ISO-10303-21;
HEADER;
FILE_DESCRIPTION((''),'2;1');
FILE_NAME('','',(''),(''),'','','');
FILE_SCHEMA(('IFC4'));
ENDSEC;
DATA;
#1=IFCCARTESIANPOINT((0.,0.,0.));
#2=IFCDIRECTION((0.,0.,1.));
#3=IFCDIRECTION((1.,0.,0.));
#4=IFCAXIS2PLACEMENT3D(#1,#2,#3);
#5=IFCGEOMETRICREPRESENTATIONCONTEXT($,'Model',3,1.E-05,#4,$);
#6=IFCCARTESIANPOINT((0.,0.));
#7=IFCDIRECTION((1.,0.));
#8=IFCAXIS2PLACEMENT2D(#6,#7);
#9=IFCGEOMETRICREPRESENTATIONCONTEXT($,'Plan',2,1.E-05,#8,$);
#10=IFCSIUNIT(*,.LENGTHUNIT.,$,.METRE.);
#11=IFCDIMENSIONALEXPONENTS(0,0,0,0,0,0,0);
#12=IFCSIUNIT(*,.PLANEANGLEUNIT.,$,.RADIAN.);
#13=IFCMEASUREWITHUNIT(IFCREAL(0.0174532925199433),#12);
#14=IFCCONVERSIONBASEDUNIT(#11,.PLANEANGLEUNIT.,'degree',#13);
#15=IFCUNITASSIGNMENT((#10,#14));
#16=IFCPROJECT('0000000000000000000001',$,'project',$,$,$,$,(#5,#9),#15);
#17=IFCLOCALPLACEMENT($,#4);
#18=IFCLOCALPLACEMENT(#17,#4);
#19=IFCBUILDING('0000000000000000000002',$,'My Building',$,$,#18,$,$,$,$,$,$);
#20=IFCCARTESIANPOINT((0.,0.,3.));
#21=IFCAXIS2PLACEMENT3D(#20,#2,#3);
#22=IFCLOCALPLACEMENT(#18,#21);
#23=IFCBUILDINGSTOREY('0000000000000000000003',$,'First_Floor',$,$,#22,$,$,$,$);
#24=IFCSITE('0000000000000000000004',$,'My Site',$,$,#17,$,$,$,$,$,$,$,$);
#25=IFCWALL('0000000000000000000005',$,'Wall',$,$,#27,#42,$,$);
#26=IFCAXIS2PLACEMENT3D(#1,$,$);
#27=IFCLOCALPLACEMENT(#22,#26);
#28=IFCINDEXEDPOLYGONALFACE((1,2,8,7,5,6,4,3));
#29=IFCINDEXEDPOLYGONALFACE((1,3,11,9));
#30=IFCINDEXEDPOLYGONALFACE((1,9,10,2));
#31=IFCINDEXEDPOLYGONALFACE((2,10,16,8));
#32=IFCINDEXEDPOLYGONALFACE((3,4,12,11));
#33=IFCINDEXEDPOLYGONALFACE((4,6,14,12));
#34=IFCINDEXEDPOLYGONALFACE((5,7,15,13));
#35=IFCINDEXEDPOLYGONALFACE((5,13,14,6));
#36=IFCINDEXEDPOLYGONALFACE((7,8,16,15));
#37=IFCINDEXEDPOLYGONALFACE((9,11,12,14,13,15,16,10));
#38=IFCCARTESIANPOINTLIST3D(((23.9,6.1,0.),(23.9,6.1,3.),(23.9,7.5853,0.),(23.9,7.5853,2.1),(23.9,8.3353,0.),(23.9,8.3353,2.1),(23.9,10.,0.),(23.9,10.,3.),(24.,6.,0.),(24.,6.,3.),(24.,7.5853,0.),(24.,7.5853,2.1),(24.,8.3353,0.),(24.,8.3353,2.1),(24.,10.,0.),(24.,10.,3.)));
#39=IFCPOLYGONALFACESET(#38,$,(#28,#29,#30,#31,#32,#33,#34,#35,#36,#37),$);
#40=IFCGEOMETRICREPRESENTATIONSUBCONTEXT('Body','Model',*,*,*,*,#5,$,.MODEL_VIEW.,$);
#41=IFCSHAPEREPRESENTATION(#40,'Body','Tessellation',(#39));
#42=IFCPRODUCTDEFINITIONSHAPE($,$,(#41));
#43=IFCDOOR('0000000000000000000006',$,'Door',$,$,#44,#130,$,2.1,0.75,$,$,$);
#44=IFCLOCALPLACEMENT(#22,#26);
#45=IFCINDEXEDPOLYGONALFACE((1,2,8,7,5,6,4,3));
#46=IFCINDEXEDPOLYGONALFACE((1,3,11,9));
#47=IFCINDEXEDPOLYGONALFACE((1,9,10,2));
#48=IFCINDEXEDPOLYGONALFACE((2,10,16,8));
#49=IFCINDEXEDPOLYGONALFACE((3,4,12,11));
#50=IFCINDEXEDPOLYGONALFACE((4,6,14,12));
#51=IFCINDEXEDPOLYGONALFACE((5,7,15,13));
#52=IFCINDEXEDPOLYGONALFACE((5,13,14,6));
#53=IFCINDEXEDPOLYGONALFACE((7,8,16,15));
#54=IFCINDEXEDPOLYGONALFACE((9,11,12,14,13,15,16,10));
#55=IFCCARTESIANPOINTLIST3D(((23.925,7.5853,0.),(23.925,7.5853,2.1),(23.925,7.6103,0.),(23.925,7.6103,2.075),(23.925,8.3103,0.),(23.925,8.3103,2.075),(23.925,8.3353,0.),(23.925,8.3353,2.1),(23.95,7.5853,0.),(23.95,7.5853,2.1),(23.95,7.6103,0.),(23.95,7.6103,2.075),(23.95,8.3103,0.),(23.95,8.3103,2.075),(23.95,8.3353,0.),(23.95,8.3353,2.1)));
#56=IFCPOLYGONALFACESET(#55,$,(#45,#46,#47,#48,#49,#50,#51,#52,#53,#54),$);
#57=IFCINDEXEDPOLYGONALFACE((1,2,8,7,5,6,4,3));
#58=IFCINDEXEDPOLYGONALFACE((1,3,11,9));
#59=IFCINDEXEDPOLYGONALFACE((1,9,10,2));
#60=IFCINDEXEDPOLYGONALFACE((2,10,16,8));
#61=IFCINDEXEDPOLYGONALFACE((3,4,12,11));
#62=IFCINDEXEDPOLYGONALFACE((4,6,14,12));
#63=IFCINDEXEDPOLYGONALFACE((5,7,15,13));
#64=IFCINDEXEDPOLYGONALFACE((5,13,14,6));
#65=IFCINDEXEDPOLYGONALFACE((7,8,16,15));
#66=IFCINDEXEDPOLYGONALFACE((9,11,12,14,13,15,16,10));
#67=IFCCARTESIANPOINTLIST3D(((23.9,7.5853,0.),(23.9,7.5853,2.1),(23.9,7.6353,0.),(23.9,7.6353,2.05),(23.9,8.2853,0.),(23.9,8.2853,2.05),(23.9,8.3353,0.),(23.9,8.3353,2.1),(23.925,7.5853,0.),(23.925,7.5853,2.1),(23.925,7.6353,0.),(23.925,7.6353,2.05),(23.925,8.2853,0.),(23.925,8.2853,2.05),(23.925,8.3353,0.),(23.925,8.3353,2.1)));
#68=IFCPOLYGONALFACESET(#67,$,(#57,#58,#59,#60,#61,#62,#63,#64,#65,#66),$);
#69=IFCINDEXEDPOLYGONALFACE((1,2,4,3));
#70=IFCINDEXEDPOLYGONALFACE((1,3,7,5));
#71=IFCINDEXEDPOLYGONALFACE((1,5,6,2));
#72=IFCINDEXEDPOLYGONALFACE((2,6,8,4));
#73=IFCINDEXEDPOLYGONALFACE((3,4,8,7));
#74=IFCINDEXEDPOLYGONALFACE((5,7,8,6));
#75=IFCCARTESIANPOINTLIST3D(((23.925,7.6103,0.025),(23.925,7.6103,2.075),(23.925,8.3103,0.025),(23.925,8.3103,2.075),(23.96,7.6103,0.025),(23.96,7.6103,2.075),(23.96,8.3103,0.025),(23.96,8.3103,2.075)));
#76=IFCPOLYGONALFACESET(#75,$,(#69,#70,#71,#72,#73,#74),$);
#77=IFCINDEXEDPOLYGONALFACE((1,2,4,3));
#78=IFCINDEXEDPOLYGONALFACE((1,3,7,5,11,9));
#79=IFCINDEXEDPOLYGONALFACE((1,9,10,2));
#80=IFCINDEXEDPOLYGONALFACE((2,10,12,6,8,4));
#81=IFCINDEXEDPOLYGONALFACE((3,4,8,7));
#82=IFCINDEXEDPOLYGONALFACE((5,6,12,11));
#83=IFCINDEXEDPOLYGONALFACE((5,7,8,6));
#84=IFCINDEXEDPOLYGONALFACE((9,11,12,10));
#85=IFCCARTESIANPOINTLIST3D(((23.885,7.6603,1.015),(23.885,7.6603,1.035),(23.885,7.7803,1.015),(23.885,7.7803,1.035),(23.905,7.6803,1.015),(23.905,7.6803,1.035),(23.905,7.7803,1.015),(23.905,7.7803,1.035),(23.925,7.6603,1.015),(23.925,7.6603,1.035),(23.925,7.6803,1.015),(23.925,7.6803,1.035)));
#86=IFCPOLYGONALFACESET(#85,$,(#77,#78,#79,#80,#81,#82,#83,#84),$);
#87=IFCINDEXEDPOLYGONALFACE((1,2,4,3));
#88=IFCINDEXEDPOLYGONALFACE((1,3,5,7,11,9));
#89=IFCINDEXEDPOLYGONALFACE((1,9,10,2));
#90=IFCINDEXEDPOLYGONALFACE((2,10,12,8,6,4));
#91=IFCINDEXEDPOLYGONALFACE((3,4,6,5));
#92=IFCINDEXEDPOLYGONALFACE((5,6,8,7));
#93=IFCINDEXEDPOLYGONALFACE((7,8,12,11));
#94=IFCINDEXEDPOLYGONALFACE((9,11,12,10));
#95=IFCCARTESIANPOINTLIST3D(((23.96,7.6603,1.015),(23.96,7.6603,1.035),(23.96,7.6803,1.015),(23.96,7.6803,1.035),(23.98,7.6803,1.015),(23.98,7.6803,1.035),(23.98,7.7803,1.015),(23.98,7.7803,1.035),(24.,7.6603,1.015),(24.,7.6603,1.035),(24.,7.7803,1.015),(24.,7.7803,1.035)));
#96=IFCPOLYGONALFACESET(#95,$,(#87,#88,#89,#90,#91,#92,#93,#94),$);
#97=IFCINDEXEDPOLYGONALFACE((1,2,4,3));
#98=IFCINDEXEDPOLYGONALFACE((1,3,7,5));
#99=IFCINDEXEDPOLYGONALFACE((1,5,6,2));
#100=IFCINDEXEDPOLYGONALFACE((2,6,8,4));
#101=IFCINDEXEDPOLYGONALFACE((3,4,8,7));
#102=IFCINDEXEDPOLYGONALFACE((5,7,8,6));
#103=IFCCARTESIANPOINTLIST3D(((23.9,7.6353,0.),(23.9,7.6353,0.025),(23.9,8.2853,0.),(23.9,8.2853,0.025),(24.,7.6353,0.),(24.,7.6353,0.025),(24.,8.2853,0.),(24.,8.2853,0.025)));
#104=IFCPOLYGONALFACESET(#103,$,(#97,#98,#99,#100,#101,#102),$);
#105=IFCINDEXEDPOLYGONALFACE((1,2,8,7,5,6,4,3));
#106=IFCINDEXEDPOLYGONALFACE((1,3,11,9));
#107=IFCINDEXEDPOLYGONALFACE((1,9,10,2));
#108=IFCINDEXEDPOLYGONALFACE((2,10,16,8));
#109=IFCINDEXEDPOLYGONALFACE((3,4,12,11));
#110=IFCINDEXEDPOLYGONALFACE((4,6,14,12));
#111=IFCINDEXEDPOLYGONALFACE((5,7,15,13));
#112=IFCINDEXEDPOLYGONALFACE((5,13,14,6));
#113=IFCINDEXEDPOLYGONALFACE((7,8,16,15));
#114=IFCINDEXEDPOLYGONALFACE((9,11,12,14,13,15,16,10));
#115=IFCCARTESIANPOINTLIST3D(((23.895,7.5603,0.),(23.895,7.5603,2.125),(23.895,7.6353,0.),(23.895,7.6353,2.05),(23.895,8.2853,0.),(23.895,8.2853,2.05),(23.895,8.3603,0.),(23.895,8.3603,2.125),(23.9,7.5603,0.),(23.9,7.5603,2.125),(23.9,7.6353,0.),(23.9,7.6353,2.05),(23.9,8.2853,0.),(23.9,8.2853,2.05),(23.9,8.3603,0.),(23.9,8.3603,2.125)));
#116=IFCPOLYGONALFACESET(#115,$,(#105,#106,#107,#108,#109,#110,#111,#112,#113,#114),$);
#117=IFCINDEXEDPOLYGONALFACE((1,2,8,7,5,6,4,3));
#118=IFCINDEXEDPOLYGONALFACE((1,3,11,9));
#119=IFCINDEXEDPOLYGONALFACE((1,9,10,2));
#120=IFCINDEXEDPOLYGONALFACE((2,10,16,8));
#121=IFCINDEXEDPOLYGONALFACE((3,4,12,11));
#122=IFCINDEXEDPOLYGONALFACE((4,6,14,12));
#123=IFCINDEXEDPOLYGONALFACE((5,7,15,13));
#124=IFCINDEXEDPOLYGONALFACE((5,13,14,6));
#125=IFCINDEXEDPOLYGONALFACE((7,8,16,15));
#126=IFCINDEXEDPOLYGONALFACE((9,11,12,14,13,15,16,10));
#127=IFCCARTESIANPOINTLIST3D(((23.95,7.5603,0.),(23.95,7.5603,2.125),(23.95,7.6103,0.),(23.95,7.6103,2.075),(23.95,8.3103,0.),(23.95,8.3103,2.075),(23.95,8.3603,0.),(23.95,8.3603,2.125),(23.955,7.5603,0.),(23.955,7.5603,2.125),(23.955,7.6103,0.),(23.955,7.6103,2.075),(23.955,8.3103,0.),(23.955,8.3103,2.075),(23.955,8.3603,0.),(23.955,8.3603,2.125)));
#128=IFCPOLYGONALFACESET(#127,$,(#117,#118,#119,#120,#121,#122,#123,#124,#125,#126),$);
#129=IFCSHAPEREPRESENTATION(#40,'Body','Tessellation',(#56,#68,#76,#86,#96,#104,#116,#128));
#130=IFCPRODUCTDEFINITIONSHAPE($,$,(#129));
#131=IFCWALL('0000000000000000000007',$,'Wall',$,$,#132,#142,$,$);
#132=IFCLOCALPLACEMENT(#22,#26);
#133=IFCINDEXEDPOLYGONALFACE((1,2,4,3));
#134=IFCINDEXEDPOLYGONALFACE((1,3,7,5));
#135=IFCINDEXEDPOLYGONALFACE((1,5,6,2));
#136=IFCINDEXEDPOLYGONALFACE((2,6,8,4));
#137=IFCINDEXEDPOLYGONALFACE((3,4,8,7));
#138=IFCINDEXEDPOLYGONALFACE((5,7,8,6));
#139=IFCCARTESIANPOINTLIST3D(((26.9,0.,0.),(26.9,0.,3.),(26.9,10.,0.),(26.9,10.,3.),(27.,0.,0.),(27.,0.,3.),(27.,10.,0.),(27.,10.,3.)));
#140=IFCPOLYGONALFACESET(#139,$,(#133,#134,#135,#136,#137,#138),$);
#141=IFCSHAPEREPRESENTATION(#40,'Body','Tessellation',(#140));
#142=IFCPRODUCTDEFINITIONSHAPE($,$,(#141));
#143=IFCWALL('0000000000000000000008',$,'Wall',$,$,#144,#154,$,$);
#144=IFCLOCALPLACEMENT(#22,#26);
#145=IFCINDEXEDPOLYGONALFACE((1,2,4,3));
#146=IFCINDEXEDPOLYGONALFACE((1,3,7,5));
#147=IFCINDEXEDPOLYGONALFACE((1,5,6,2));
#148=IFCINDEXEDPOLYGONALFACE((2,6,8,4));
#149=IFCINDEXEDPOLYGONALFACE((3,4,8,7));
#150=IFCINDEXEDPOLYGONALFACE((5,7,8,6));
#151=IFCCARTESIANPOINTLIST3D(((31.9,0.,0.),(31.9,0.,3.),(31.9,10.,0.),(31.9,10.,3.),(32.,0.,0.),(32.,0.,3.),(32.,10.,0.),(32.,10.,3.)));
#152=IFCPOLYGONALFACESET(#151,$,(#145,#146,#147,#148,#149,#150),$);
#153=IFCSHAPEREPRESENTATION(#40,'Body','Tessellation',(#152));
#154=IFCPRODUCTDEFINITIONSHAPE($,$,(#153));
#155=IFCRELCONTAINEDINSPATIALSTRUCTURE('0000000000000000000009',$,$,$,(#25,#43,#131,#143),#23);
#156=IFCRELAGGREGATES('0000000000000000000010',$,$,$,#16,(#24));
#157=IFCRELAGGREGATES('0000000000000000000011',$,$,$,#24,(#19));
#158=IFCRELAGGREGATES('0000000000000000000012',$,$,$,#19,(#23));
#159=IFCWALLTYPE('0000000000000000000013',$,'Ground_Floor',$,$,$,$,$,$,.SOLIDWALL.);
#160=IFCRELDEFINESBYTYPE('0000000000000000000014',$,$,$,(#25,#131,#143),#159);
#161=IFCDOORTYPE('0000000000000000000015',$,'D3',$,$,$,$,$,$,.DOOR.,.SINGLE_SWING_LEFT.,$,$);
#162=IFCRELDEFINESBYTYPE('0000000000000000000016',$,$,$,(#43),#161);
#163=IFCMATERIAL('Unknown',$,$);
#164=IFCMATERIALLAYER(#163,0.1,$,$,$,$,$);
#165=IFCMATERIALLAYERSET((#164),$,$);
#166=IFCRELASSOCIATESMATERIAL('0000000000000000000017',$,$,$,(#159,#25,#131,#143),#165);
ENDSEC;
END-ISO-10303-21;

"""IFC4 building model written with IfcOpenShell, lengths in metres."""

from ifc_helpers import new_model, entity, si_unit, converted_unit, frame, origin_with_axes, origin_2d_with_axis, place, context, subcontext, project, spatial, line, indexed_curve, outline, extrude, shape, source, transform, mapped, material, layer, layer_set, layer_usage, type_object, type_shapes, element, fill, save


model = new_model("IFC4")

# Units and contexts
model_context = context("Model", 3, precision=1e-05, world=origin_with_axes())
plan_context = context("Plan", 2, precision=1e-05, world=origin_2d_with_axis())
body_context_1 = subcontext(model_context, "Body", "Model", "MODEL_VIEW")
body_context_2 = subcontext(plan_context, "Body", "Plan", "PLAN_VIEW")
ifc_project = project(units=[si_unit("LENGTHUNIT", "METRE"), converted_unit("PLANEANGLEUNIT", "degree", entity("IfcReal", 0.0174532925199433), si_unit("PLANEANGLEUNIT", "RADIAN"), dimensions=[0, 0, 0, 0, 0, 0, 0])], contexts=[model_context, plan_context])

# Site, building, storey
site_placement = place(None, origin_with_axes())
site = spatial("IfcSite", under=ifc_project, at=site_placement, Name="My Site")
building_placement = place(site_placement, origin_with_axes())
building = spatial("IfcBuilding", under=site, at=building_placement, Name="My Building")
storey_placement = place(building_placement, frame((0.0, 0.0, 3.0), z_axis=(0.0, 0.0, 1.0), x_axis=(1.0, 0.0, 0.0)))
storey = spatial("IfcBuildingStorey", under=building, at=storey_placement, Name="First_Floor")

# Shared definitions
ifc_material = material(Name="Unknown")

# Wall, opening, door
ifc_layer = layer(ifc_material, 0.1)
ifc_layer_set = layer_set([ifc_layer])
ifc_layer_usage_1 = layer_usage(ifc_layer_set, "AXIS2", "POSITIVE", 0.0)
wall_type = type_object("IfcWallType", Name="Ground_Floor", PredefinedType="SOLIDWALL", material=ifc_layer_set)
wall_1_placement = place(storey_placement, frame((24.0, 6.0, 0.0), z_axis=(0.0, 0.0, 1.0), x_axis=(0.0, 1.0, 0.0)))
wall_1 = element("IfcWall", 1, at=wall_1_placement, inside=storey, type_object=wall_type, material=ifc_layer_usage_1, Name="Wall", context=body_context_1, shape_type="SweptSolid", body=[
    extrude(outline(indexed_curve([(0.0, 0.0), (0.1, 0.1), (4.0, 0.1), (4.0, 0.0)], segments=[line(1, 2, 3, 4, 1)])), origin_with_axes(), (0.0, 0.0, 1.0), 3.0),
])
shared_shape_1 = source(origin_with_axes(), body_context_1, "Body", "SweptSolid", [
    extrude(outline(indexed_curve([(0.0, 0.0), (0.75, 0.0), (0.75, 2.1), (0.0, 2.1)], segments=[line(1, 2, 3, 4, 1)])), frame((0.0, -0.6, 0.0), z_axis=(0.0, -1.0, 0.0), x_axis=(1.0, 0.0, 0.0)), (0.0, 0.0, -1.0), 1.2),
])
opening_1_placement = place(wall_1_placement, frame((2.3353, 0.1, 0.0), z_axis=(0.0, 0.0, 1.0), x_axis=(-1.0, 0.0, 0.0)))
opening_1 = element("IfcOpeningElement", 2, at=opening_1_placement, cuts=wall_1, PredefinedType="OPENING", context=body_context_1, shape_type="MappedRepresentation", body=[
    mapped(shared_shape_1, transform((0.0, 0.0, 0.0), x_axis=(1.0, 0.0, 0.0), y_axis=(0.0, 1.0, 0.0), z_axis=(0.0, 0.0, 1.0), scale=1.0)),
])
door_type_1 = type_object("IfcDoorType", Name="D3", OperationType="SINGLE_SWING_LEFT", PredefinedType="DOOR")
shared_shape_2 = source(origin_with_axes(), body_context_1, "Body", "SweptSolid", [
    extrude(outline(indexed_curve([(0.0, 0.0), (0.0, 2.1), (0.75, 2.1), (0.75, 0.0), (0.725, 0.0), (0.725, 2.075), (0.025, 2.075), (0.025, 0.0)], segments=[line(1, 2, 3, 4, 5, 6, 7, 8, 1)])), frame((0.0, 0.025, 0.0), z_axis=(0.0, -1.0, 0.0), x_axis=(1.0, 0.0, 0.0)), (0.0, 0.0, -1.0), 0.025),
    extrude(outline(indexed_curve([(0.0, 0.0), (0.0, 2.1), (0.75, 2.1), (0.75, 0.0), (0.7, 0.0), (0.7, 2.05), (0.05, 2.05), (0.05, 0.0)], segments=[line(1, 2, 3, 4, 5, 6, 7, 8, 1)])), frame((0.0, 0.0, 0.0), z_axis=(0.0, -1.0, 0.0), x_axis=(1.0, 0.0, 0.0)), (0.0, 0.0, -1.0), 0.025),
    extrude(outline(indexed_curve([(0.0, 0.0), (0.7, 0.0), (0.7, 0.035), (0.0, 0.035)], segments=[line(1, 2, 3, 4, 1)])), frame((0.025, 0.025, 0.025), z_axis=(0.0, 0.0, 1.0), x_axis=(1.0, 0.0, 0.0)), (0.0, 0.0, 1.0), 2.05),
    extrude(outline(indexed_curve([(0.0, 0.0), (0.0, -0.04), (-0.12, -0.04), (-0.12, -0.02), (-0.02, -0.02), (-0.02, 0.0)], segments=[line(1, 2, 3, 4, 5, 6, 1)])), frame((0.675, 0.025, 1.015), z_axis=(0.0, 0.0, 1.0), x_axis=(1.0, 0.0, 0.0)), (0.0, 0.0, 1.0), 0.02),
    extrude(outline(indexed_curve([(0.0, 0.0), (0.0, 0.04), (-0.12, 0.04), (-0.12, 0.02), (-0.02, 0.02), (-0.02, 0.0)], segments=[line(1, 2, 3, 4, 5, 6, 1)])), frame((0.675, 0.06, 1.015), z_axis=(0.0, 0.0, 1.0), x_axis=(1.0, 0.0, 0.0)), (0.0, 0.0, 1.0), 0.02),
    extrude(outline(indexed_curve([(0.0, 0.0), (0.65, 0.0), (0.65, 0.1), (0.0, 0.1)], segments=[line(1, 2, 3, 4, 1)])), frame((0.05, 0.0, 0.0), z_axis=(0.0, 0.0, 1.0), x_axis=(1.0, 0.0, 0.0)), (0.0, 0.0, 1.0), 0.025),
    extrude(outline(indexed_curve([(0.0, 0.0), (0.0, 2.125), (0.8, 2.125), (0.8, 0.0), (0.725, 0.0), (0.725, 2.05), (0.075, 2.05), (0.075, 0.0)], segments=[line(1, 2, 3, 4, 5, 6, 7, 8, 1)])), frame((-0.025, -0.005, 0.0), z_axis=(0.0, -1.0, 0.0), x_axis=(1.0, 0.0, 0.0)), (0.0, 0.0, -1.0), 0.005),
    extrude(outline(indexed_curve([(0.0, 0.0), (0.0, 2.125), (0.8, 2.125), (0.8, 0.0), (0.75, 0.0), (0.75, 2.075), (0.05, 2.075), (0.05, 0.0)], segments=[line(1, 2, 3, 4, 5, 6, 7, 8, 1)])), frame((-0.025, 0.05, 0.0), z_axis=(0.0, -1.0, 0.0), x_axis=(1.0, 0.0, 0.0)), (0.0, 0.0, -1.0), 0.005),
])
shared_shape_3 = source(origin_with_axes(), body_context_2, "Body", "Curve2D", [
    entity("IfcIndexedPolyCurve", entity("IfcCartesianPointList2D", [[0.0, 0.0], [0.0, 0.05], [0.025, 0.05], [0.025, 0.025], [0.05, 0.025], [0.05, 0.0]]), [entity("IfcLineIndex", [1, 2, 3, 4, 5, 6, 1])]),
    entity("IfcIndexedPolyCurve", entity("IfcCartesianPointList2D", [[0.75, 0.0], [0.75, 0.05], [0.725, 0.05], [0.725, 0.025], [0.7, 0.025], [0.7, 0.0]]), [entity("IfcLineIndex", [1, 2, 3, 4, 5, 6, 1])]),
    entity("IfcTrimmedCurve", entity("IfcEllipse", entity("IfcAxis2Placement2D", entity("IfcCartesianPoint", [0.06, 0.05]), entity("IfcDirection", [1.0, 0.0])), 0.665, 0.7), [entity("IfcCartesianPoint", [0.725, 0.05])], [entity("IfcCartesianPoint", [0.06, 0.75])], True, "CARTESIAN"),
    entity("IfcIndexedPolyCurve", entity("IfcCartesianPointList2D", [[0.025, 0.05], [0.06, 0.05], [0.06, 0.75], [0.025, 0.75]]), [entity("IfcLineIndex", [1, 2, 3, 4, 1])]),
])
type_shapes(door_type_1, [shared_shape_2, shared_shape_3])
door_1_placement = place(opening_1_placement, frame((0.0, 0.0, 0.0), z_axis=(0.0, 0.0, 1.0), x_axis=(1.0, 0.0, 0.0)))
door_1 = element("IfcDoor", 3, at=door_1_placement, inside=storey, type_object=door_type_1, Name="Door", OverallHeight=2.1, OverallWidth=0.75, shapes=[
    shape(body_context_1, "Body", "MappedRepresentation", [mapped(shared_shape_2, transform((0.0, 0.0, 0.0), x_axis=(1.0, 0.0, 0.0), y_axis=(0.0, 1.0, 0.0), z_axis=(0.0, 0.0, 1.0), scale=1.0))]),
    shape(body_context_2, "Body", "MappedRepresentation", [mapped(shared_shape_3, transform((0.0, 0.0, 0.0), x_axis=(1.0, 0.0, 0.0), y_axis=(0.0, 1.0, 0.0), z_axis=(0.0, 0.0, 1.0), scale=1.0))]),
])
fill(opening_1, door_1)

# Walls
ifc_layer_usage_2 = layer_usage(ifc_layer_set, "AXIS2", "POSITIVE", 0.0)
wall_2_placement = place(storey_placement, frame((26.9, 10.0, 0.0), z_axis=(0.0, 0.0, 1.0), x_axis=(0.0, -1.0, 0.0)))
element("IfcWall", 4, at=wall_2_placement, inside=storey, type_object=wall_type, material=ifc_layer_usage_2, Name="Wall", context=body_context_1, shape_type="SweptSolid", body=[
    extrude(outline(indexed_curve([(0.0, 0.0), (0.0, 0.1), (10.0, 0.1), (10.0, 0.0)], segments=[line(1, 2, 3, 4, 1)])), origin_with_axes(), (0.0, 0.0, 1.0), 3.0),
])
ifc_layer_usage_3 = layer_usage(ifc_layer_set, "AXIS2", "POSITIVE", 0.0)
wall_3_placement = place(storey_placement, frame((31.9, 10.0, 0.0), z_axis=(0.0, 0.0, 1.0), x_axis=(0.0, -1.0, 0.0)))
element("IfcWall", 5, at=wall_3_placement, inside=storey, type_object=wall_type, material=ifc_layer_usage_3, Name="Wall", context=body_context_1, shape_type="SweptSolid", body=[
    extrude(outline(indexed_curve([(0.0, 0.0), (0.0, 0.1), (10.0, 0.1), (10.0, 0.0)], segments=[line(1, 2, 3, 4, 1)])), origin_with_axes(), (0.0, 0.0, 1.0), 3.0),
])

save(model, "model.ifc")
